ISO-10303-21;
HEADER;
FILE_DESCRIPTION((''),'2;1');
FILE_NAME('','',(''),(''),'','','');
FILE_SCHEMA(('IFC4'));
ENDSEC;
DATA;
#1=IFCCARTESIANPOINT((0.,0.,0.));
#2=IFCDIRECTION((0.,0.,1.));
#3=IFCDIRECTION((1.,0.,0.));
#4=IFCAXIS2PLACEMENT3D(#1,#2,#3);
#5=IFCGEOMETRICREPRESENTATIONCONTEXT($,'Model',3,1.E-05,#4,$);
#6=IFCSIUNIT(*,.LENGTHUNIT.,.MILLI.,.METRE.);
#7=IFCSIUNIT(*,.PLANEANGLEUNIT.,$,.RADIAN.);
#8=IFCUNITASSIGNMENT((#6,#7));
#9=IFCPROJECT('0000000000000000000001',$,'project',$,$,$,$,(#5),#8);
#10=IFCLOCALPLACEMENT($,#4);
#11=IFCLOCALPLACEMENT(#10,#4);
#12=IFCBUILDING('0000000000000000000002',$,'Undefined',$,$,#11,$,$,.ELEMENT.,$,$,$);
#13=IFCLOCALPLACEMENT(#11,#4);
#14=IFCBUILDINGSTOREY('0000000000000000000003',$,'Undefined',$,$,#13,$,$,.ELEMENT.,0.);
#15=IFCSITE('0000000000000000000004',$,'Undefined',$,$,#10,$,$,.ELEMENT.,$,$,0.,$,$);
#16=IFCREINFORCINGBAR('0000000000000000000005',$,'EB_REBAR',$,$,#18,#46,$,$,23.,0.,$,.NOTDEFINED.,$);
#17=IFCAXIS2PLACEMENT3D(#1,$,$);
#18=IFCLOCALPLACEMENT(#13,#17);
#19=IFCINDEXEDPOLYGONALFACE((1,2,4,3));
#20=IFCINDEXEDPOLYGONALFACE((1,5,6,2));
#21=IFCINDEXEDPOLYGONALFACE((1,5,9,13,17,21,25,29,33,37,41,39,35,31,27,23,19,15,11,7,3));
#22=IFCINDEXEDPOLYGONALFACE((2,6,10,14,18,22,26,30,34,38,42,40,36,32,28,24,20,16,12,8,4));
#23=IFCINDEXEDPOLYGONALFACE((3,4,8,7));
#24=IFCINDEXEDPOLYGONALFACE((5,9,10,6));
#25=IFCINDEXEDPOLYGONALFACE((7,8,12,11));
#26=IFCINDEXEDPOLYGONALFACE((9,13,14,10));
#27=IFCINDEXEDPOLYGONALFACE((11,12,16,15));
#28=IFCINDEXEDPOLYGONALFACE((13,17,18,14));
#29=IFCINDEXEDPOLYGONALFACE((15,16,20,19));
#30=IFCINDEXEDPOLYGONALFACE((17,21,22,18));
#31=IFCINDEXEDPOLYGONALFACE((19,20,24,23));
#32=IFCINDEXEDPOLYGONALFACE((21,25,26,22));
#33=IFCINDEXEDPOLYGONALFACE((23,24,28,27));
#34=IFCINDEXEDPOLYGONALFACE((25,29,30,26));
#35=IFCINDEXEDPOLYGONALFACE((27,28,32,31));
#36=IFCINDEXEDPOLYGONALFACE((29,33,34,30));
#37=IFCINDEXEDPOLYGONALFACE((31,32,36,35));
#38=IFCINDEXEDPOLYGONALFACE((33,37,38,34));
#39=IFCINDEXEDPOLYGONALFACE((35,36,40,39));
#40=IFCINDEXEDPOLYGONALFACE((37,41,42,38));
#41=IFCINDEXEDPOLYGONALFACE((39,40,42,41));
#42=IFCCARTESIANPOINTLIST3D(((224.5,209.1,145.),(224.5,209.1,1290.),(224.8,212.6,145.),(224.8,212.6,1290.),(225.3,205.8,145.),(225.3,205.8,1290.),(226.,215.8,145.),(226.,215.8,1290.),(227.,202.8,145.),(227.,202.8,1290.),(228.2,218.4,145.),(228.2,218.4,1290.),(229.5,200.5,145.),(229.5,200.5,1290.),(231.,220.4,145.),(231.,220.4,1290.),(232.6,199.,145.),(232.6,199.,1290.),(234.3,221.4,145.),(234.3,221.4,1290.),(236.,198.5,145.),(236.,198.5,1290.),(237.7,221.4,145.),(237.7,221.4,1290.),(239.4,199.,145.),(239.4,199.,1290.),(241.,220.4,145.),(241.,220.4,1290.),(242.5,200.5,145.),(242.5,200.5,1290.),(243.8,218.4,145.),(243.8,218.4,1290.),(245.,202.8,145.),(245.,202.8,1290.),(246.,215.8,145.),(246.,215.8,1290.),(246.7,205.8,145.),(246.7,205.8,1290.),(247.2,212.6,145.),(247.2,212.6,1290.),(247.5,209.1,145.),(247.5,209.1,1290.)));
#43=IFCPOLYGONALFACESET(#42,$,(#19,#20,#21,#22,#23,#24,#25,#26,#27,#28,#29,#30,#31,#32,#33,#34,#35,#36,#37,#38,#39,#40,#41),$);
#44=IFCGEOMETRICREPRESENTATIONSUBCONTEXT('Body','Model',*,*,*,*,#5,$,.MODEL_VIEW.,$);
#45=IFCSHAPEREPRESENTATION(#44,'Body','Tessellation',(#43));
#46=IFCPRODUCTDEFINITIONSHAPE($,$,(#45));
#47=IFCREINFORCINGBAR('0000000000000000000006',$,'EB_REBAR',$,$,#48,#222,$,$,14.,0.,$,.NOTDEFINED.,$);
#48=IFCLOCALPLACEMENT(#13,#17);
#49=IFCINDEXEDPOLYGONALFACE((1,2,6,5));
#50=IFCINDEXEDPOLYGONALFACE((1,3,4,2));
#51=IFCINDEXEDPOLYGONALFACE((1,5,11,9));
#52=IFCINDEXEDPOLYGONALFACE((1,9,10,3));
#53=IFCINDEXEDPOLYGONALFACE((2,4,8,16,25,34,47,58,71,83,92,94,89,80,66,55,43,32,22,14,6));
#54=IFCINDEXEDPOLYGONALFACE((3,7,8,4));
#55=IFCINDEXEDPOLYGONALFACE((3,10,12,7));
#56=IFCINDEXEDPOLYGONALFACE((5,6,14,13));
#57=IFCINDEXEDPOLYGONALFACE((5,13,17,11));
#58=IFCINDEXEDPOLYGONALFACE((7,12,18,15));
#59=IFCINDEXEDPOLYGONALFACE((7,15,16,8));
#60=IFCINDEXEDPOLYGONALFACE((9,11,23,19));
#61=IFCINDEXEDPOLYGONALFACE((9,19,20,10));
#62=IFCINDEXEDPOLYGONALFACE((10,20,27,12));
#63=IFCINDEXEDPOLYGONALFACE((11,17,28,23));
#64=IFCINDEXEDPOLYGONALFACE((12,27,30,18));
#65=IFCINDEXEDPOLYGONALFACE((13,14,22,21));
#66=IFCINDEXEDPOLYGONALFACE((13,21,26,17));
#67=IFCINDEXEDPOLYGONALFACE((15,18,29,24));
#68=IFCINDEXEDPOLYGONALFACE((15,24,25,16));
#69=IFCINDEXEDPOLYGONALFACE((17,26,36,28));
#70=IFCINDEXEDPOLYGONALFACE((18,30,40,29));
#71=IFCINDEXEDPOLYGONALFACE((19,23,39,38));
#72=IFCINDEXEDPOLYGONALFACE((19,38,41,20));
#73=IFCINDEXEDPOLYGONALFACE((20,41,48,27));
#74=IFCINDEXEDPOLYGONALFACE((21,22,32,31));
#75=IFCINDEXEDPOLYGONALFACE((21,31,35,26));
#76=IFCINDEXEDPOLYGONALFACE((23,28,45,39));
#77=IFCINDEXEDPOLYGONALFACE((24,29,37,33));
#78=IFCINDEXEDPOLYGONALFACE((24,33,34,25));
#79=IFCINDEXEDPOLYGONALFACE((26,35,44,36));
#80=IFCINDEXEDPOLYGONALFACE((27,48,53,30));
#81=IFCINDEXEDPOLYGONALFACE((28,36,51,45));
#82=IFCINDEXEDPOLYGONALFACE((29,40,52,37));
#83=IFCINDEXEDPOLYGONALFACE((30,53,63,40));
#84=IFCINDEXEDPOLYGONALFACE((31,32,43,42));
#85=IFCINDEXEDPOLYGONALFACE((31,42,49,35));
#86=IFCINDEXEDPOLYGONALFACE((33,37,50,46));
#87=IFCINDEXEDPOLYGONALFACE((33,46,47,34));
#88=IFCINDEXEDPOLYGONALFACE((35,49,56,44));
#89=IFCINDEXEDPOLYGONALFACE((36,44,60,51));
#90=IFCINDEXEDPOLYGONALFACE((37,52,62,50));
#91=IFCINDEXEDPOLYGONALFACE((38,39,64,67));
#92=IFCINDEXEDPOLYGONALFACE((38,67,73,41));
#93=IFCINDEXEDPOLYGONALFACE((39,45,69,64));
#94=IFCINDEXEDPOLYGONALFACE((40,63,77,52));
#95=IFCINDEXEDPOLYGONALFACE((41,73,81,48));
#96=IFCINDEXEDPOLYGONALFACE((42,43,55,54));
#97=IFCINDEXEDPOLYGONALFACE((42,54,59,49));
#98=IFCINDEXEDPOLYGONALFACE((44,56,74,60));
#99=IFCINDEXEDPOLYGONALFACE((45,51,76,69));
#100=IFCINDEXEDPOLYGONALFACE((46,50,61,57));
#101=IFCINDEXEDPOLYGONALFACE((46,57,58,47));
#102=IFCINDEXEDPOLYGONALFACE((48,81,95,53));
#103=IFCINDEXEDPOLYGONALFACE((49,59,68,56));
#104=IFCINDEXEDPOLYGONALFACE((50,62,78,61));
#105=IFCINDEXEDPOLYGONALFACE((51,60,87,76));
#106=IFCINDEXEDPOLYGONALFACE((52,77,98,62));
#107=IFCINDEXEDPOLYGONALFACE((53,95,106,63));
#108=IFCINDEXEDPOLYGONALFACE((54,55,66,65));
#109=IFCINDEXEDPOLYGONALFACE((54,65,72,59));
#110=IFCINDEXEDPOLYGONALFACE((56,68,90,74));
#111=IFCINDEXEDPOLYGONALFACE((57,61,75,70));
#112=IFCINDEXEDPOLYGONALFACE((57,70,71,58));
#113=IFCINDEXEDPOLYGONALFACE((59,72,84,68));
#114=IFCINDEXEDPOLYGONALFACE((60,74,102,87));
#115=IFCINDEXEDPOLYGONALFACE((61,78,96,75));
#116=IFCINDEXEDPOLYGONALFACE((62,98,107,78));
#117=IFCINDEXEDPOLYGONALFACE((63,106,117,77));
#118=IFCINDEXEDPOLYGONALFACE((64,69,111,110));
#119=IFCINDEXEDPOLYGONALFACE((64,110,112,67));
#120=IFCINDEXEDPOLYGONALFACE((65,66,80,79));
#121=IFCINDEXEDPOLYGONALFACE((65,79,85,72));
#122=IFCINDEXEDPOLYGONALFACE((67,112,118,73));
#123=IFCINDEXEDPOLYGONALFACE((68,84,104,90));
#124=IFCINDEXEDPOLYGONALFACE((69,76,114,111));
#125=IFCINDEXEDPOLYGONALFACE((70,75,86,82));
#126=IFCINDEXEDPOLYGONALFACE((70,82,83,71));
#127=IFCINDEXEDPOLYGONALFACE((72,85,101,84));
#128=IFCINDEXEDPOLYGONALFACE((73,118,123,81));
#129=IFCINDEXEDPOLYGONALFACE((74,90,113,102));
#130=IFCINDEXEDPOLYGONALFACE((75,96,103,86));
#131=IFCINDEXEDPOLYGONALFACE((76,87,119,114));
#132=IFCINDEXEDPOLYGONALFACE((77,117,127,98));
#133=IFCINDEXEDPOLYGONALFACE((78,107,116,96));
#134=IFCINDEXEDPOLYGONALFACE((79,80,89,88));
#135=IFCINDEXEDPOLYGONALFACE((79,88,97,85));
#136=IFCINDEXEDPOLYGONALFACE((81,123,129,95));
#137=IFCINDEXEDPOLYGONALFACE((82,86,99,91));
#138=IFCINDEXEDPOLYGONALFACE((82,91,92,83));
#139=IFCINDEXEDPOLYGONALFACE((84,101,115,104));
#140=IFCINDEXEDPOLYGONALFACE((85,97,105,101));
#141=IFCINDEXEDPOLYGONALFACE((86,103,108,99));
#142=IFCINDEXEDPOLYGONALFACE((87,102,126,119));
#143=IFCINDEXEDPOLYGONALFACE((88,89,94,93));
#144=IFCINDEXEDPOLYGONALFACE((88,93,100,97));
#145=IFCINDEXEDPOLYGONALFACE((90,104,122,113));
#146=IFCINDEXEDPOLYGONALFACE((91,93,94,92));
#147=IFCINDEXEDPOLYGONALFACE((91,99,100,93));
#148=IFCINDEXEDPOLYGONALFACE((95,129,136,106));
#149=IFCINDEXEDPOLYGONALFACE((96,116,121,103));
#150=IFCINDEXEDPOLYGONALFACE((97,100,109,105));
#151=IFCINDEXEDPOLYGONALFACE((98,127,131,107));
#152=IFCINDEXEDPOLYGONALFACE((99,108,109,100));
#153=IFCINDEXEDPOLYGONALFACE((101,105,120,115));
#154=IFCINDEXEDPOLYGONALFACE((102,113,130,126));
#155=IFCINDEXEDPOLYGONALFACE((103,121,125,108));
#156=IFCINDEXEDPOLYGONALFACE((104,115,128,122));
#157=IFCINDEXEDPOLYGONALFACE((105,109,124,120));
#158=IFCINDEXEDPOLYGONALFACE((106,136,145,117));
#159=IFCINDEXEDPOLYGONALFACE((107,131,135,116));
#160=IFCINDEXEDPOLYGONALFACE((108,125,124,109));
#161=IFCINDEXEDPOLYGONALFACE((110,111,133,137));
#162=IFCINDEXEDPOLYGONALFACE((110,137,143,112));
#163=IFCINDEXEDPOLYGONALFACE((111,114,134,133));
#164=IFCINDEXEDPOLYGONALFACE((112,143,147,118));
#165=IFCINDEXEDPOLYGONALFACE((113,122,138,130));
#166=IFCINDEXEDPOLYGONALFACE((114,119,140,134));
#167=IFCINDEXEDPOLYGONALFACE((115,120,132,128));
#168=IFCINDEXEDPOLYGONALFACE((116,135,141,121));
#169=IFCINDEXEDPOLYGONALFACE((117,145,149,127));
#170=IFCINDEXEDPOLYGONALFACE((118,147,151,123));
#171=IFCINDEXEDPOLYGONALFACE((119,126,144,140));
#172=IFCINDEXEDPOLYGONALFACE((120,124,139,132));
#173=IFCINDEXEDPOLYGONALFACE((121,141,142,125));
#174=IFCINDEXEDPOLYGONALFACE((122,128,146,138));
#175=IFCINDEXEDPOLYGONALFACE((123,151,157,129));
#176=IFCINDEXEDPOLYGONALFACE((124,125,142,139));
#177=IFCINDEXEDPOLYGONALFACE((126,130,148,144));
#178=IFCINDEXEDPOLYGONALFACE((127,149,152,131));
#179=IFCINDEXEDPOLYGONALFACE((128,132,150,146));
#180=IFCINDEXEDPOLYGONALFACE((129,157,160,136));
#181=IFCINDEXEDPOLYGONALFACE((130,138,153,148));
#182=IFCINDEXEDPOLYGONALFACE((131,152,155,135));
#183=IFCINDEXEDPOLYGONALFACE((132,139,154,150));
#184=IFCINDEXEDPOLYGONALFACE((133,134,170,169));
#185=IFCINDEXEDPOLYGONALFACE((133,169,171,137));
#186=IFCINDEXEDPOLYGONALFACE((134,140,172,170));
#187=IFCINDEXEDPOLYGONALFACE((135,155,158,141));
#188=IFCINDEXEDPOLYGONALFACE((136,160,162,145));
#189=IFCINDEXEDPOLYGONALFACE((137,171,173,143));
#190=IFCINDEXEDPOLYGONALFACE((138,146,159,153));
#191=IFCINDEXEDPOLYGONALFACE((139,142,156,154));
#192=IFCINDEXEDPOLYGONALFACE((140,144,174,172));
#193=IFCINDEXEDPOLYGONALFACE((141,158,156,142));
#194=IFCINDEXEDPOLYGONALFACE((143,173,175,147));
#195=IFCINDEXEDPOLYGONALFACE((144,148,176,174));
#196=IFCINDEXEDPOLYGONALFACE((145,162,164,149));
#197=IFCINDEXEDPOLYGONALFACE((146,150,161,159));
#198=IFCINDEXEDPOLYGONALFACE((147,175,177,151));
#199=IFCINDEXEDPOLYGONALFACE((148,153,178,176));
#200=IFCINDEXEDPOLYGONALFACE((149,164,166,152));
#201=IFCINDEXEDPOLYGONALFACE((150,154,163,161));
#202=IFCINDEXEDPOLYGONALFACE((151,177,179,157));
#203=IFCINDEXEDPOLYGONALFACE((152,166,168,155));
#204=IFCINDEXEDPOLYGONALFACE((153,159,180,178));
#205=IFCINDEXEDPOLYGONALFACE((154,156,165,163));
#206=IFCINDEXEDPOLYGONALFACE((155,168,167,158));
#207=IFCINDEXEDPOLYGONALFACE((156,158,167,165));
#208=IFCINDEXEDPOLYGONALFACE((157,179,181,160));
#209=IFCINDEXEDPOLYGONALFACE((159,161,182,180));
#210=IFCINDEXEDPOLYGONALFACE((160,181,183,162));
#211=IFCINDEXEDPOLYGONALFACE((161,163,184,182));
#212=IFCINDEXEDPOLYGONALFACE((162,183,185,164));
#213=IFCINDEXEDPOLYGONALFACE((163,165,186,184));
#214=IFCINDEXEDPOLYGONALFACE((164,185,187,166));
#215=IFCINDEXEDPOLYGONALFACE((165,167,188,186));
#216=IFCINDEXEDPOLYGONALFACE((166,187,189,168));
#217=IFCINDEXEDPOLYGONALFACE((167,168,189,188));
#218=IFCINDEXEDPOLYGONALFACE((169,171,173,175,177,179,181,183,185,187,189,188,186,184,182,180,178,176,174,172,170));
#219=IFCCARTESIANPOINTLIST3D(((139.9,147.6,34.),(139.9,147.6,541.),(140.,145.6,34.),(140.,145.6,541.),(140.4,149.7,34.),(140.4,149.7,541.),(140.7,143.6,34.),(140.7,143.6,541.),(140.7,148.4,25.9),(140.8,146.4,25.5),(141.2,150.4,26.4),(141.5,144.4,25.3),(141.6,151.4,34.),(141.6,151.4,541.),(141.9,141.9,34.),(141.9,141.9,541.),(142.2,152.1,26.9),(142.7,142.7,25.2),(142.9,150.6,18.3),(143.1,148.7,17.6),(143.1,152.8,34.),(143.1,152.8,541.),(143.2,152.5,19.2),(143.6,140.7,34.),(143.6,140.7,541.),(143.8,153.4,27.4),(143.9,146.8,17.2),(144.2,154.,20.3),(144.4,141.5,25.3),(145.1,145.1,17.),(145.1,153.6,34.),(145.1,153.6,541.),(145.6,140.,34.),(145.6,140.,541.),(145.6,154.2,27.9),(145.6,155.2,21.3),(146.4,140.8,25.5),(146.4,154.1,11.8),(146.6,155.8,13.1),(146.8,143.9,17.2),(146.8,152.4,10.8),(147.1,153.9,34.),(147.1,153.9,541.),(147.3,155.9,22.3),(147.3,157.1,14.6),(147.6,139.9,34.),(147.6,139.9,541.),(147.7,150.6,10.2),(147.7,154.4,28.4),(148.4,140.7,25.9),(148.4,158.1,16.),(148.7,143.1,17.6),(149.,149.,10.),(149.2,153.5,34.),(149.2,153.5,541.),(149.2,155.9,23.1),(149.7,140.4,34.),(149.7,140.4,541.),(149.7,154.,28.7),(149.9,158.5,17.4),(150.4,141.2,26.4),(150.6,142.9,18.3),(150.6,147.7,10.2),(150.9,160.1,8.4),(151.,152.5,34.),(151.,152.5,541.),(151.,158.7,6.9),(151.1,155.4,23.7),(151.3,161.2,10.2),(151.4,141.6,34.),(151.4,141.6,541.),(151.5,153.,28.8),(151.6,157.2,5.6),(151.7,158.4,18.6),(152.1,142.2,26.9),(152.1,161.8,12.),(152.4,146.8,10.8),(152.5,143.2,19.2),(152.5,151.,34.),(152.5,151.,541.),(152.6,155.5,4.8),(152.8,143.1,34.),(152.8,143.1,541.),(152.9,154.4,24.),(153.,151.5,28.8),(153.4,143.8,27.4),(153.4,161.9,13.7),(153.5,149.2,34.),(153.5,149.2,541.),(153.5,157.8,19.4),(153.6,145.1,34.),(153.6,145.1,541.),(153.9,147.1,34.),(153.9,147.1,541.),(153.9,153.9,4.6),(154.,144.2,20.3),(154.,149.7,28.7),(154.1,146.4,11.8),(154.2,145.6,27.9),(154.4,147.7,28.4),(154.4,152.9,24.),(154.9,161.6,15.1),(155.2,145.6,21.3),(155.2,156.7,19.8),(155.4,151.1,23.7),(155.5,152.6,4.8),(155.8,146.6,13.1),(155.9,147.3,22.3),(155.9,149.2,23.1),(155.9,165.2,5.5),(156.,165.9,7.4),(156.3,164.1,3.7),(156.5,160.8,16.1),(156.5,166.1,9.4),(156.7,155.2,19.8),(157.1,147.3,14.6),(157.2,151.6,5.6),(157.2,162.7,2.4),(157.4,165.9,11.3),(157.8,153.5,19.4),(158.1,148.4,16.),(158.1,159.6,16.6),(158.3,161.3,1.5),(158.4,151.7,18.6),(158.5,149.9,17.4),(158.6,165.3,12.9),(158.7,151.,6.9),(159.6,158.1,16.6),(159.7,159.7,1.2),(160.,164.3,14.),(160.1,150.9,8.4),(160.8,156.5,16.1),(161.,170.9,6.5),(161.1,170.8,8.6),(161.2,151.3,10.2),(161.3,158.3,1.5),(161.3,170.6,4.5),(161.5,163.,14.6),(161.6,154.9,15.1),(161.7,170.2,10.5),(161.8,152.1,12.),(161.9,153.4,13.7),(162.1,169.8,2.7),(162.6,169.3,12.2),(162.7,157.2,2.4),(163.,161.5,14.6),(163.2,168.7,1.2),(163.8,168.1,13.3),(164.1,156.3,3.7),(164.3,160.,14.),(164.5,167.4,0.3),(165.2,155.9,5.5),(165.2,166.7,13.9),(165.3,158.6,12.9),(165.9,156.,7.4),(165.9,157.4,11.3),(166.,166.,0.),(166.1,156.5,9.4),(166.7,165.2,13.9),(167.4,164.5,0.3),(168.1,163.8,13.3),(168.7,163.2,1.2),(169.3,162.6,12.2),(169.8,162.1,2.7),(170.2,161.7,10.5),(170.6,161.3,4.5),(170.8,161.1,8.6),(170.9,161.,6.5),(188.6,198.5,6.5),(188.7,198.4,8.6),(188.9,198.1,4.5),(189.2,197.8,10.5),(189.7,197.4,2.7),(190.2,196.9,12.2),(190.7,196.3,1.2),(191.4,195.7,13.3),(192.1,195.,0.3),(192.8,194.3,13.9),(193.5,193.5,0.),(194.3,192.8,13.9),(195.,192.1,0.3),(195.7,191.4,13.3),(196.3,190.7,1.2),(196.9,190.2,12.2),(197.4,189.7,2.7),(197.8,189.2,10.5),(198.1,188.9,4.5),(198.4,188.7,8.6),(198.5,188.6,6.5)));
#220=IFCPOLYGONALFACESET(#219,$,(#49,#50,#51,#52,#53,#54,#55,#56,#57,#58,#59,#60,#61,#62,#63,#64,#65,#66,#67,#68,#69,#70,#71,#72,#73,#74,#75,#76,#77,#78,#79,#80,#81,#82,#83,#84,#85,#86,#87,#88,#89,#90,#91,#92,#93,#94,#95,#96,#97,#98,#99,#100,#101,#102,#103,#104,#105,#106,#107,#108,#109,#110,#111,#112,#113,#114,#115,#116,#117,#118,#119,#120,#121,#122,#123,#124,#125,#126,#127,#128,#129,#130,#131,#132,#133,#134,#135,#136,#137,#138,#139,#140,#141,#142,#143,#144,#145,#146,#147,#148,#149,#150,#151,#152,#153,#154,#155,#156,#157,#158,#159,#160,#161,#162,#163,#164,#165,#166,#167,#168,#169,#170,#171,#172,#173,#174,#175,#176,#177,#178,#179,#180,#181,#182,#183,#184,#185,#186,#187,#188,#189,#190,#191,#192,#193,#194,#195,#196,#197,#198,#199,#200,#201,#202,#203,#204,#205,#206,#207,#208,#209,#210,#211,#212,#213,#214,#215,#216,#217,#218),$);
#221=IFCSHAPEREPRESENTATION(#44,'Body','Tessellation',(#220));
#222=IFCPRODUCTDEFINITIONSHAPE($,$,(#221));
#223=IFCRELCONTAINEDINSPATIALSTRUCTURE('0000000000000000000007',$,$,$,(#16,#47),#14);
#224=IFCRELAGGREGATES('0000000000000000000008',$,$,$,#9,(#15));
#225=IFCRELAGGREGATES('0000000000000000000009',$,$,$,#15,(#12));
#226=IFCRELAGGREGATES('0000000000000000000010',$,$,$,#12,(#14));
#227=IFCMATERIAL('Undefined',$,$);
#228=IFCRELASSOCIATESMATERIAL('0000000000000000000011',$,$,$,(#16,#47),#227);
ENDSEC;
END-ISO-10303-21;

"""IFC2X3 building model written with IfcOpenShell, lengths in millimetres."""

from ifc_helpers import new_model, entity, si_unit, frame, origin_with_axes, place, context, subcontext, project, spatial, source, transform, mapped, material, element, save


model = new_model("IFC2X3")

# Units and contexts
model_context = context("Model", 3, precision=1e-05, world=origin_with_axes())
body_context = subcontext(model_context, "Body", "Model", "MODEL_VIEW")
ifc_project = project(units=[si_unit("LENGTHUNIT", "METRE", prefix="MILLI"), si_unit("PLANEANGLEUNIT", "RADIAN")], contexts=[model_context])

# Site, building, storey
site_placement = place(None, origin_with_axes())
site = spatial("IfcSite", under=ifc_project, at=site_placement, Name="Undefined", CompositionType="ELEMENT", RefElevation=0.0)
building_placement = place(site_placement, origin_with_axes())
building = spatial("IfcBuilding", under=site, at=building_placement, Name="Undefined", CompositionType="ELEMENT")
storey_placement = place(building_placement, origin_with_axes())
storey = spatial("IfcBuildingStorey", under=building, at=storey_placement, Name="Undefined", CompositionType="ELEMENT", Elevation=0.0)

# Reinforcing bars
ifc_material_1 = material(Name="Undefined")
shared_shape_1 = source(origin_with_axes(), body_context, "Body", "AdvancedSweptSolid", [
    entity("IfcSweptDiskSolid", entity("IfcTrimmedCurve", entity("IfcLine", entity("IfcCartesianPoint", [0.0, 0.0, 0.0]), entity("IfcVector", entity("IfcDirection", [1.0, 0.0, 0.0]), 1.0)), [entity("IfcParameterValue", 0.0)], [entity("IfcParameterValue", 1144.999996)], True, "PARAMETER"), 11.5, None, 0.0, 1145.0),
])
reinforcing_bar_1_placement = place(storey_placement, frame((236.0, 210.0, 145.0), z_axis=(0.0, -1.0, 0.0), x_axis=(0.0, 0.0, 1.0)))
element("IfcReinforcingBar", 1, at=reinforcing_bar_1_placement, inside=storey, material=ifc_material_1, Name="EB_REBAR", BarRole="NOTDEFINED", CrossSectionArea=0.0, NominalDiameter=23.0, context=body_context, shape_type="MappedRepresentation", body=[
    mapped(shared_shape_1, transform((0.0, 0.0, 0.0))),
])
shared_shape_2 = source(origin_with_axes(), body_context, "Body", "AdvancedSweptSolid", [
    entity("IfcSweptDiskSolid", entity("IfcCompositeCurve", [entity("IfcCompositeCurveSegment", "CONTINUOUS", True, entity("IfcTrimmedCurve", entity("IfcLine", entity("IfcCartesianPoint", [0.0, 0.0, 0.0]), entity("IfcVector", entity("IfcDirection", [0.0, 0.0, -1.0]), 1.0)), [entity("IfcParameterValue", 0.0)], [entity("IfcParameterValue", 39.002617)], True, "PARAMETER")), entity("IfcCompositeCurveSegment", "CONTINUOUS", True, entity("IfcTrimmedCurve", entity("IfcCircle", entity("IfcAxis2Placement3D", entity("IfcCartesianPoint", [27.0, 0.0, -39.0]), entity("IfcDirection", [0.0, -1.0, 0.0]), entity("IfcDirection", [-1.0, 0.0, 0.0])), 27.0), [entity("IfcParameterValue", 0.0)], [entity("IfcParameterValue", 1.570797)], True, "PARAMETER")), entity("IfcCompositeCurveSegment", "DISCONTINUOUS", True, entity("IfcTrimmedCurve", entity("IfcLine", entity("IfcCartesianPoint", [27.0, 0.0, -66.0]), entity("IfcVector", entity("IfcDirection", [1.0, 0.0, 0.0]), 1.0)), [entity("IfcParameterValue", 0.0)], [entity("IfcParameterValue", 506.999983)], True, "PARAMETER"))], False), 7.0, None, 0.0, 547.6),
])
reinforcing_bar_2_placement = place(storey_placement, frame((155.9, 155.9, 7.0), z_axis=(0.707107, 0.707107, 0.000001), x_axis=(-0.000001, -0.000001, 1.0)))
element("IfcReinforcingBar", 2, at=reinforcing_bar_2_placement, inside=storey, material=ifc_material_1, Name="EB_REBAR", BarRole="NOTDEFINED", CrossSectionArea=0.0, NominalDiameter=14.0, context=body_context, shape_type="MappedRepresentation", body=[
    mapped(shared_shape_2, transform((0.0, 0.0, 53.2))),
])

save(model, "model.ifc")
